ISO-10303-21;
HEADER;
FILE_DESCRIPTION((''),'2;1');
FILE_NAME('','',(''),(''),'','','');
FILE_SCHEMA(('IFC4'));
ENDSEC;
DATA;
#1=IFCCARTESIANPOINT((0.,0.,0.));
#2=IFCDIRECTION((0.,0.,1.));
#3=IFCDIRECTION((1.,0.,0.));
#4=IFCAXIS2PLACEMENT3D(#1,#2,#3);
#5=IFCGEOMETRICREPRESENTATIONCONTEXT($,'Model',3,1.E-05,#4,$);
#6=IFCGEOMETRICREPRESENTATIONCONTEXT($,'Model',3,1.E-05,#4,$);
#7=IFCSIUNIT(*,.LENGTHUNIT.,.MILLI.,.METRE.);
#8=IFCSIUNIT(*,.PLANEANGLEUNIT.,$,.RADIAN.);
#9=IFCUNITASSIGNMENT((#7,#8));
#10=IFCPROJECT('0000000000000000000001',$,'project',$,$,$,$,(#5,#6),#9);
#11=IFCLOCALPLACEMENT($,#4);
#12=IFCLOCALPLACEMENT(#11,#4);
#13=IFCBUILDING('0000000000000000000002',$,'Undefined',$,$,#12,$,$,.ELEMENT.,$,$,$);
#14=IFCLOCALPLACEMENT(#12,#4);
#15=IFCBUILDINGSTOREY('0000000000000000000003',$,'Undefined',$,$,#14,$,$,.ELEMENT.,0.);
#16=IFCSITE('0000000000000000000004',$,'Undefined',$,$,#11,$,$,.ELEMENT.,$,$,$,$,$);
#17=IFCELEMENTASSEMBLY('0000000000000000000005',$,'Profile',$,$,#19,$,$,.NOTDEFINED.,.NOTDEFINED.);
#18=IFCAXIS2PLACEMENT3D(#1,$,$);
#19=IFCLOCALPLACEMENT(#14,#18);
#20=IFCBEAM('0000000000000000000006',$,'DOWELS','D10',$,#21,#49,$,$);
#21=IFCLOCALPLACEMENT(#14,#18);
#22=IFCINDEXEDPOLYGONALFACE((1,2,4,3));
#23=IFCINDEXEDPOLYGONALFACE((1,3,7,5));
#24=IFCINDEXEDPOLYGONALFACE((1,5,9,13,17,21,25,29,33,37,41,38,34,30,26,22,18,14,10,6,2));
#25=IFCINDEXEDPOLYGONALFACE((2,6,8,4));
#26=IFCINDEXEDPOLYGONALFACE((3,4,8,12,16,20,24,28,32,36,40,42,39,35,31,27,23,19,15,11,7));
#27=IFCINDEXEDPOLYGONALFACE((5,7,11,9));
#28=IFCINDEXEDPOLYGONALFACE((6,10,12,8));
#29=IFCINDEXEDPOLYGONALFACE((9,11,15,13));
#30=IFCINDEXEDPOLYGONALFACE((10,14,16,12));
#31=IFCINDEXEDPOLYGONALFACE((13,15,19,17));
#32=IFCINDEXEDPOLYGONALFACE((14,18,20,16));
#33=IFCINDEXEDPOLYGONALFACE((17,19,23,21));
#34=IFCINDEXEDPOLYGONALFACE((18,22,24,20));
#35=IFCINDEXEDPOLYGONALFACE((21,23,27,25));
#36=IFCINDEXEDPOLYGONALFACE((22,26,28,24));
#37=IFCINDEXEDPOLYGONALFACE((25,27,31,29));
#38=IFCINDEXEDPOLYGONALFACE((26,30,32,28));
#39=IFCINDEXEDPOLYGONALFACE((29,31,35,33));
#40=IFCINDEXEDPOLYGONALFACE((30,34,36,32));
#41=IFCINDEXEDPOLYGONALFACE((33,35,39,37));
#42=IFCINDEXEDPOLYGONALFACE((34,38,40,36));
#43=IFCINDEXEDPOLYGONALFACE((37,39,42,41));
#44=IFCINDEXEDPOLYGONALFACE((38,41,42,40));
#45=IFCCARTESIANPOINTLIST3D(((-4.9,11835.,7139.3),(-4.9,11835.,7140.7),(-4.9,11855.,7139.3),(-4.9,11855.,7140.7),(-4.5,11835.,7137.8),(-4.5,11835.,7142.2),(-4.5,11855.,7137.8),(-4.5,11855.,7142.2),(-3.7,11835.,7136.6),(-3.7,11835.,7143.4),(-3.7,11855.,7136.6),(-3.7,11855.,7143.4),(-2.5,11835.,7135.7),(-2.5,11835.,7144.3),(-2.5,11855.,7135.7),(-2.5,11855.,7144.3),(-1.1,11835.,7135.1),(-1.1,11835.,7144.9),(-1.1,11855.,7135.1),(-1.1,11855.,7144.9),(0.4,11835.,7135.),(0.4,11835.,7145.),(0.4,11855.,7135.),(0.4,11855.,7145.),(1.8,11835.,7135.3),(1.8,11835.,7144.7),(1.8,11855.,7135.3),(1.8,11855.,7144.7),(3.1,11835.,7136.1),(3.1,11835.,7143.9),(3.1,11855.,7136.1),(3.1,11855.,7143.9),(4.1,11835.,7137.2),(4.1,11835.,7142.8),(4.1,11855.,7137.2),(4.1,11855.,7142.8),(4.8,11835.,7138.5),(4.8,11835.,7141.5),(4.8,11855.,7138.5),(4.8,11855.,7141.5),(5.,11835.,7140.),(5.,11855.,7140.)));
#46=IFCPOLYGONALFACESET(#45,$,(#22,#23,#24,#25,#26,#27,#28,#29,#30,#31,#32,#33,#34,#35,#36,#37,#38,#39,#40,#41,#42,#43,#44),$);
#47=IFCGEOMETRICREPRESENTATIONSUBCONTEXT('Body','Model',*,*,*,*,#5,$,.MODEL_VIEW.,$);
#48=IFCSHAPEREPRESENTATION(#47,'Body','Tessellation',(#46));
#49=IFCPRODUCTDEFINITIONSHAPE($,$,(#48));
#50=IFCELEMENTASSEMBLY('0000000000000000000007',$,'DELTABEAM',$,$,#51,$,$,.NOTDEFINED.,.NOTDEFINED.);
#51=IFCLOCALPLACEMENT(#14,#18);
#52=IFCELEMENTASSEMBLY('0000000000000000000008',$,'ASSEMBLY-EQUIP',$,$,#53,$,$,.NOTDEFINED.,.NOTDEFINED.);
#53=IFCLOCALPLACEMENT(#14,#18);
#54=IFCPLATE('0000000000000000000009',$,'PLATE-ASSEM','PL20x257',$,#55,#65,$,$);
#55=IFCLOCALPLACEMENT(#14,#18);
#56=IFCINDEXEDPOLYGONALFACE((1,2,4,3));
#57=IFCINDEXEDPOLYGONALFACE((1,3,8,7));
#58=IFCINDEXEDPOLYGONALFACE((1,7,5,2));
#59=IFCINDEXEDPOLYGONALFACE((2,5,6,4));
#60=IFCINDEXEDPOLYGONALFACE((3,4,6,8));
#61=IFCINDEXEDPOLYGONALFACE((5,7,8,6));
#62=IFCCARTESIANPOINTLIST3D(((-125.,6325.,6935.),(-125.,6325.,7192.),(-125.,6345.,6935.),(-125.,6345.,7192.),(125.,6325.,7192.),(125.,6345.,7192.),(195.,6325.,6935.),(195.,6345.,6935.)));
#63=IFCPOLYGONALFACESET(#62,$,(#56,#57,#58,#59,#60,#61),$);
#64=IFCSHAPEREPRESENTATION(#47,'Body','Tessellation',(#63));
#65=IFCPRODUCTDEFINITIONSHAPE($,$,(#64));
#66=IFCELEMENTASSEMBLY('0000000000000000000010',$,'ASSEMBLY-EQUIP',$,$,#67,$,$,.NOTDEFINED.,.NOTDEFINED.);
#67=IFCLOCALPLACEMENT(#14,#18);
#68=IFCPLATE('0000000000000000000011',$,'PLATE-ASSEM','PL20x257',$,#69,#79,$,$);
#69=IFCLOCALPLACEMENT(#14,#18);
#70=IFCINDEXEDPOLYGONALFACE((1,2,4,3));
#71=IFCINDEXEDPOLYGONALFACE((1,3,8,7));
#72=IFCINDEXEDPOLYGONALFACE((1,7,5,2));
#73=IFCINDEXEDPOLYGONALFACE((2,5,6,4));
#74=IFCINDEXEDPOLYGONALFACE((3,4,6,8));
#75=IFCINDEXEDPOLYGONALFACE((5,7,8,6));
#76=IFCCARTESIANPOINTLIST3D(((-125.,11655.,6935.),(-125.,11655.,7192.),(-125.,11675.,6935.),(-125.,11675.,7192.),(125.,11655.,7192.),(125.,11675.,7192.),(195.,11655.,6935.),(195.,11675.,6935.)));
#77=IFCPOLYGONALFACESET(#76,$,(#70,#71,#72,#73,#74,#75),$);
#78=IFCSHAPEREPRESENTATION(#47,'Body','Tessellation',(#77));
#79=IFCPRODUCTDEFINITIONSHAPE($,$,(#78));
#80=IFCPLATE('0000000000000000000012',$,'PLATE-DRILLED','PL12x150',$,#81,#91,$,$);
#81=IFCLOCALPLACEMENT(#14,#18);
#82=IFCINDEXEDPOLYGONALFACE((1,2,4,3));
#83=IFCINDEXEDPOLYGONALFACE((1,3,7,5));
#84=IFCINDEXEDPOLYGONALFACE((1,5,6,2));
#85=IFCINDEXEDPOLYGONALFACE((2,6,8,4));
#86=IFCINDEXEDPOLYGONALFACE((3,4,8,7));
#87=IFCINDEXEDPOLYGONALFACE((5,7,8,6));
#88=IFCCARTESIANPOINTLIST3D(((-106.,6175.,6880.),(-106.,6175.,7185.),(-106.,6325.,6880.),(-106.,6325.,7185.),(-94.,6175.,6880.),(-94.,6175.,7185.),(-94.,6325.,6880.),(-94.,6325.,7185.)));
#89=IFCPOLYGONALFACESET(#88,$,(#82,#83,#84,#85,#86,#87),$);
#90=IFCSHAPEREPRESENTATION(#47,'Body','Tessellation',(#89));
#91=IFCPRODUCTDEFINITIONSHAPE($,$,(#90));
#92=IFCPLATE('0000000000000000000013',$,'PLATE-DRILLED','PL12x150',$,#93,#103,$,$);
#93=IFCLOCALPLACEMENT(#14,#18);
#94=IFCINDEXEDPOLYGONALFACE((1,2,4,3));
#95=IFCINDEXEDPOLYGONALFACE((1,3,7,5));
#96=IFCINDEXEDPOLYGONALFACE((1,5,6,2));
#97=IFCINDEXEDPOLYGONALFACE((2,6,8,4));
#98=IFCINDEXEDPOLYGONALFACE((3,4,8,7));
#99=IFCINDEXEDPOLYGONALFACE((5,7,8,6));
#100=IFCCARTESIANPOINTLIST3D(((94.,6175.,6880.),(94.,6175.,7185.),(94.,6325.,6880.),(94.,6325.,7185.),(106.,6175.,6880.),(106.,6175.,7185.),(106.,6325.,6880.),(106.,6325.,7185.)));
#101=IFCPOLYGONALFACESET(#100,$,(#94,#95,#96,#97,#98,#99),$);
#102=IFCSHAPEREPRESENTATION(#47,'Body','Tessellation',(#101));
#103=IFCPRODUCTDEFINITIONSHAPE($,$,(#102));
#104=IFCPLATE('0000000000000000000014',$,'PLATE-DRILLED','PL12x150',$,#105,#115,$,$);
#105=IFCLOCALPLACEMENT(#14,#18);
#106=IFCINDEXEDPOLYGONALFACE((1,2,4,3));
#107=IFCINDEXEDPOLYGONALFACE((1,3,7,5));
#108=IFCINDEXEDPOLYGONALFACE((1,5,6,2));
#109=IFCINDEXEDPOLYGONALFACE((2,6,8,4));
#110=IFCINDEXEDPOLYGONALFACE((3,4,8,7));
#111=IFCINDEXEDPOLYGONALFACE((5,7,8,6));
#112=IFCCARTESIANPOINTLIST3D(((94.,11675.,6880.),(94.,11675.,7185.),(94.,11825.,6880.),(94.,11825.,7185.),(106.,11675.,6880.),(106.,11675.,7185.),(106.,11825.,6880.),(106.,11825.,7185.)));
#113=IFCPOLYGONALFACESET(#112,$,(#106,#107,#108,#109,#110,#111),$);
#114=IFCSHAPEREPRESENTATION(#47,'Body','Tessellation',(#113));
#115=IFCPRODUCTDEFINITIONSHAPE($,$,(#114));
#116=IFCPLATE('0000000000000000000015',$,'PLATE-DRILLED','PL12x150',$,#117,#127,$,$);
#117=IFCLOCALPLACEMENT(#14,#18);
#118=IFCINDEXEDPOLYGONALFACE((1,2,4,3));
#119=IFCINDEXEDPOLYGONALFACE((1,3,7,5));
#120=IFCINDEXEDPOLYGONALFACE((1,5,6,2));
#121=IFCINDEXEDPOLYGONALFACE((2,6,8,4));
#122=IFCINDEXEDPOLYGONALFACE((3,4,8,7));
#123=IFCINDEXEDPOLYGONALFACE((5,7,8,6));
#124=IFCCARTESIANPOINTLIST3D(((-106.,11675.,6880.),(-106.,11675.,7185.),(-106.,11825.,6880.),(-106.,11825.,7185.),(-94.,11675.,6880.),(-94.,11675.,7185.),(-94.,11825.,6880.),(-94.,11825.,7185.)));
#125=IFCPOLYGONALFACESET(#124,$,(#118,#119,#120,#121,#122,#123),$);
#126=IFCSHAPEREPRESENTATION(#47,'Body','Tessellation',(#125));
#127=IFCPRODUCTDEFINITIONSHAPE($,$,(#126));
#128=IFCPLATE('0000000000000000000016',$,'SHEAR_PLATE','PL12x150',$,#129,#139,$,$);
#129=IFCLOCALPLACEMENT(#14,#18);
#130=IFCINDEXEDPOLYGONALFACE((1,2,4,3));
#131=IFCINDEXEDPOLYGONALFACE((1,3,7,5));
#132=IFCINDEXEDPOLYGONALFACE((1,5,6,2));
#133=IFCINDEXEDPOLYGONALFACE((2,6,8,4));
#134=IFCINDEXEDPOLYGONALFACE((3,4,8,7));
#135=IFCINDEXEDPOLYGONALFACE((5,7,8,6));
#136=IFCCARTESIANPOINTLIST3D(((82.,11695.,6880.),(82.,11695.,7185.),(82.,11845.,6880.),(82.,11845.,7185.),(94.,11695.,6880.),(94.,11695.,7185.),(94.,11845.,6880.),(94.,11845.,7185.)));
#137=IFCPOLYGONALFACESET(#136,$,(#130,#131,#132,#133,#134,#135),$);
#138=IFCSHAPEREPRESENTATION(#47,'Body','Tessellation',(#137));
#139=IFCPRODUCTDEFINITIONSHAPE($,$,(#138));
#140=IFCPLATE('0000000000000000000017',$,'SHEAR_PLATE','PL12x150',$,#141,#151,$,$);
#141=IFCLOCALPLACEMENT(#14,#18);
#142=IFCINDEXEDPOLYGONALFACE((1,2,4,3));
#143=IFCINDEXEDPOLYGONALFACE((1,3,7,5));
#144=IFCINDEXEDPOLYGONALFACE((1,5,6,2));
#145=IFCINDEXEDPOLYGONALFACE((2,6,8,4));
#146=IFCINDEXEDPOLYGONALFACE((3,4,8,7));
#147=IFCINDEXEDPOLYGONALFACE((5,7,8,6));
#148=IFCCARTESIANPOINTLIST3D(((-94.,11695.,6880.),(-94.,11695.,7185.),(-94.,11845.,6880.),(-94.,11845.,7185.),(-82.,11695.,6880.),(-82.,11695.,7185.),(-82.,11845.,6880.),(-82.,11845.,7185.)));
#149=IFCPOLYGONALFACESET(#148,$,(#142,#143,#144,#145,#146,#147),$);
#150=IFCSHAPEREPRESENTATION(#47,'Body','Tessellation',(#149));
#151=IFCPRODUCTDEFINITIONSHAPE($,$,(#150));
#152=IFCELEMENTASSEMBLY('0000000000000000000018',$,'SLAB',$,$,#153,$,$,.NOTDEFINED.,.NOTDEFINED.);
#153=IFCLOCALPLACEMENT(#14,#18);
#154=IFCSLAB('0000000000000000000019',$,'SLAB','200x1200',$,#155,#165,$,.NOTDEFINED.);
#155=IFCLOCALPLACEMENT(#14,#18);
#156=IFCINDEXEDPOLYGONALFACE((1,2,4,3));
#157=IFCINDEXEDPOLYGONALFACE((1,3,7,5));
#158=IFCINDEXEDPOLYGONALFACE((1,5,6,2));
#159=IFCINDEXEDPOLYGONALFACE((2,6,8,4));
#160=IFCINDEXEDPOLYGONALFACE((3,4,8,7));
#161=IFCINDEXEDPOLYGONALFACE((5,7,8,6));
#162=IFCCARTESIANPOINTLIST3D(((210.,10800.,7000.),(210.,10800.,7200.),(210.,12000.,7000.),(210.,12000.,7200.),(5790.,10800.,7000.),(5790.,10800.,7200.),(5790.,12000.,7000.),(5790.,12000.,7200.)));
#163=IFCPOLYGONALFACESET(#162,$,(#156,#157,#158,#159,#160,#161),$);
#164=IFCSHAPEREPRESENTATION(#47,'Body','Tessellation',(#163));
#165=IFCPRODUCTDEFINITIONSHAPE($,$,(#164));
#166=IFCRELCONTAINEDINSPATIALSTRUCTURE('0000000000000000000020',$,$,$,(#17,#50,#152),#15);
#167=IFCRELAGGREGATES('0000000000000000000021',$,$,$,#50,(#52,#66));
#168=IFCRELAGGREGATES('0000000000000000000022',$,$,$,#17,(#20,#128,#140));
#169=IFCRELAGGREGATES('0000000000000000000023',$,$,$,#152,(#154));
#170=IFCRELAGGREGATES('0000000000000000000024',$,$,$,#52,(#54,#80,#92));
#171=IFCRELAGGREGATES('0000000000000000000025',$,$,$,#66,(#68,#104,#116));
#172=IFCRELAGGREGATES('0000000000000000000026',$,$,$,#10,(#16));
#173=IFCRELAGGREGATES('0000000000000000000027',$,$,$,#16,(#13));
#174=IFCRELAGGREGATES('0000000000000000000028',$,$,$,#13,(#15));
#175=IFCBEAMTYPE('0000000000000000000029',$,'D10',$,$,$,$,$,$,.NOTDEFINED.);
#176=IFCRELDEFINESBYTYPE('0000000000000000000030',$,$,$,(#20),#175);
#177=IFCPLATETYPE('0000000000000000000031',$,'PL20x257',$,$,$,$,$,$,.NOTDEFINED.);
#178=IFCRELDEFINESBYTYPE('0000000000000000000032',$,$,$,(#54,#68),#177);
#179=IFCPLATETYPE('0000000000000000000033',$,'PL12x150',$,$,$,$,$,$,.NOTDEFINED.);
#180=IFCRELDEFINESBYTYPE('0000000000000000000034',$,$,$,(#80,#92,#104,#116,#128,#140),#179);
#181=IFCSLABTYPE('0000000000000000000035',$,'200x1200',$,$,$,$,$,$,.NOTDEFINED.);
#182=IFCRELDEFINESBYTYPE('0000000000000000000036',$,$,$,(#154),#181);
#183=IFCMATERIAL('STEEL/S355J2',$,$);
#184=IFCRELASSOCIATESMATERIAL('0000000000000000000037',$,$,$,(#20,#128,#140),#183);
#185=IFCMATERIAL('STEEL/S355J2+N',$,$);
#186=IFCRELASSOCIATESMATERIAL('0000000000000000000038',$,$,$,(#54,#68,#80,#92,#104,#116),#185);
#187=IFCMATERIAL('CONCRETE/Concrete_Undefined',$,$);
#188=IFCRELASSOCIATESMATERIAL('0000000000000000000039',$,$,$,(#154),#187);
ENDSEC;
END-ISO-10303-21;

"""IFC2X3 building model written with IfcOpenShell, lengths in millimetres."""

from ifc_helpers import new_model, si_unit, frame, origin_with_axes, origin_2d_with_axis, place, context, subcontext, project, spatial, polyline, circle, outline, extrude, material, type_object, element, aggregate, save


model = new_model("IFC2X3")

# Units and contexts
model_context_1 = context("Model", 3, precision=1e-05, world=origin_with_axes())
model_context_2 = context("Model", 3, precision=1e-05, world=origin_with_axes())
body_context = subcontext(model_context_1, "Body", "Model", "MODEL_VIEW")
ifc_project = project(units=[si_unit("LENGTHUNIT", "METRE", prefix="MILLI"), si_unit("PLANEANGLEUNIT", "RADIAN")], contexts=[model_context_1, model_context_2])

# Site, building, storey
site_placement = place(None, origin_with_axes())
site = spatial("IfcSite", under=ifc_project, at=site_placement, Name="Undefined", CompositionType="ELEMENT")
building_placement = place(site_placement, origin_with_axes())
building = spatial("IfcBuilding", under=site, at=building_placement, Name="Undefined", CompositionType="ELEMENT")
storey_placement = place(building_placement, origin_with_axes())
storey = spatial("IfcBuildingStorey", under=building, at=storey_placement, Name="Undefined", CompositionType="ELEMENT", Elevation=0.0)

# Element assembly, beam
assembly_1_placement = place(storey_placement, origin_with_axes())
assembly_1 = element("IfcElementAssembly", 1, at=assembly_1_placement, inside=storey, Name="Profile", AssemblyPlace="NOTDEFINED", PredefinedType="NOTDEFINED")
ifc_material_1 = material(Name="STEEL/S355J2")
beam_type_1 = type_object("IfcBeamType", Name="D10", PredefinedType="NOTDEFINED")
beam_1_placement = place(assembly_1_placement, frame((0.0, 11835.0, 7140.0), z_axis=(0.0, 0.0, 1.0), x_axis=(0.0, 1.0, 0.0)))
beam_1 = element("IfcBeam", 2, at=beam_1_placement, type_object=beam_type_1, material=ifc_material_1, Name="DOWELS", Description="D10", context=body_context, shape_type="SweptSolid", body=[
    extrude(circle(Radius=5.0, at=origin_2d_with_axis()), frame((20.0, 0.0, 0.0), z_axis=(-1.0, 0.0, 0.0), x_axis=(0.0, -1.0, 0.0)), (0.0, 0.0, 1.0), 20.0),
])

# Element assemblies, plates
assembly_2_placement = place(storey_placement, origin_with_axes())
assembly_2 = element("IfcElementAssembly", 3, at=assembly_2_placement, inside=storey, Name="DELTABEAM", AssemblyPlace="NOTDEFINED", PredefinedType="NOTDEFINED")
assembly_3_placement = place(assembly_2_placement, origin_with_axes())
assembly_3 = element("IfcElementAssembly", 4, at=assembly_3_placement, Name="ASSEMBLY-EQUIP", AssemblyPlace="NOTDEFINED", PredefinedType="NOTDEFINED")
ifc_material_2 = material(Name="STEEL/S355J2+N")
plate_type_1 = type_object("IfcPlateType", Name="PL20x257", PredefinedType="NOTDEFINED")
plate_1_placement = place(assembly_3_placement, frame((195.0, 6335.0, 6935.0), z_axis=(0.0, 1.0, 0.0), x_axis=(-1.0, 0.0, 0.0)))
plate_1 = element("IfcPlate", 5, at=plate_1_placement, type_object=plate_type_1, material=ifc_material_2, Name="PLATE-ASSEM", Description="PL20x257", context=body_context, shape_type="SweptSolid", body=[
    extrude(outline(polyline([(0.0, 0.0), (320.0, 0.0), (320.0, 257.0), (70.0, 257.0), (0.0, 0.0)])), frame((0.0, 0.0, -10.0), z_axis=(0.0, 0.0, 1.0), x_axis=(1.0, 0.0, 0.0)), (0.0, 0.0, 1.0), 20.0),
])
assembly_4_placement = place(assembly_2_placement, origin_with_axes())
assembly_4 = element("IfcElementAssembly", 6, at=assembly_4_placement, Name="ASSEMBLY-EQUIP", AssemblyPlace="NOTDEFINED", PredefinedType="NOTDEFINED")
aggregate(assembly_2, [assembly_3, assembly_4])
plate_2_placement = place(assembly_4_placement, frame((-125.0, 11665.0, 6935.0), z_axis=(0.0, -1.0, 0.0), x_axis=(1.0, 0.0, 0.0)))
plate_2 = element("IfcPlate", 7, at=plate_2_placement, type_object=plate_type_1, material=ifc_material_2, Name="PLATE-ASSEM", Description="PL20x257", context=body_context, shape_type="SweptSolid", body=[
    extrude(outline(polyline([(0.0, 0.0), (320.0, 0.0), (250.0, 257.0), (0.0, 257.0), (0.0, 0.0)])), frame((0.0, 0.0, -10.0), z_axis=(0.0, 0.0, 1.0), x_axis=(1.0, 0.0, 0.0)), (0.0, 0.0, 1.0), 20.0),
])
plate_type_2 = type_object("IfcPlateType", Name="PL12x150", PredefinedType="NOTDEFINED")
plate_3_placement = place(assembly_3_placement, frame((-100.0, 6325.0, 7185.0), z_axis=(1.0, 0.0, 0.0), x_axis=(0.0, -1.0, 0.0)))
plate_3 = element("IfcPlate", 8, at=plate_3_placement, type_object=plate_type_2, material=ifc_material_2, Name="PLATE-DRILLED", Description="PL12x150", context=body_context, shape_type="SweptSolid", body=[
    extrude(outline(polyline([(0.0, 0.0), (150.0, 0.0), (150.0, 0.0), (150.0, 305.0), (150.0, 305.0), (0.0, 305.0), (0.0, 305.0), (0.0, 0.0)])), frame((0.0, 0.0, -6.0), z_axis=(0.0, 0.0, 1.0), x_axis=(1.0, 0.0, 0.0)), (0.0, 0.0, 1.0), 12.0),
])
plate_4_placement = place(assembly_3_placement, frame((100.0, 6325.0, 7185.0), z_axis=(1.0, 0.0, 0.0), x_axis=(0.0, -1.0, 0.0)))
plate_4 = element("IfcPlate", 9, at=plate_4_placement, type_object=plate_type_2, material=ifc_material_2, Name="PLATE-DRILLED", Description="PL12x150", context=body_context, shape_type="SweptSolid", body=[
    extrude(outline(polyline([(0.0, 0.0), (150.0, 0.0), (150.0, 0.0), (150.0, 305.0), (150.0, 305.0), (0.0, 305.0), (0.0, 305.0), (0.0, 0.0)])), frame((0.0, 0.0, -6.0), z_axis=(0.0, 0.0, 1.0), x_axis=(1.0, 0.0, 0.0)), (0.0, 0.0, 1.0), 12.0),
])
plate_5_placement = place(assembly_4_placement, frame((100.0, 11675.0, 7185.0), z_axis=(-1.0, 0.0, 0.0), x_axis=(0.0, 1.0, 0.0)))
plate_5 = element("IfcPlate", 10, at=plate_5_placement, type_object=plate_type_2, material=ifc_material_2, Name="PLATE-DRILLED", Description="PL12x150", context=body_context, shape_type="SweptSolid", body=[
    extrude(outline(polyline([(0.0, 0.0), (150.0, 0.0), (150.0, 0.0), (150.0, 305.0), (150.0, 305.0), (0.0, 305.0), (0.0, 305.0), (0.0, 0.0)])), frame((0.0, 0.0, -6.0), z_axis=(0.0, 0.0, 1.0), x_axis=(1.0, 0.0, 0.0)), (0.0, 0.0, 1.0), 12.0),
])
plate_6_placement = place(assembly_4_placement, frame((-100.0, 11675.0, 7185.0), z_axis=(-1.0, 0.0, 0.0), x_axis=(0.0, 1.0, 0.0)))
plate_6 = element("IfcPlate", 11, at=plate_6_placement, type_object=plate_type_2, material=ifc_material_2, Name="PLATE-DRILLED", Description="PL12x150", context=body_context, shape_type="SweptSolid", body=[
    extrude(outline(polyline([(0.0, 0.0), (150.0, 0.0), (150.0, 0.0), (150.0, 305.0), (150.0, 305.0), (0.0, 305.0), (0.0, 305.0), (0.0, 0.0)])), frame((0.0, 0.0, -6.0), z_axis=(0.0, 0.0, 1.0), x_axis=(1.0, 0.0, 0.0)), (0.0, 0.0, 1.0), 12.0),
])

# Plates
plate_7_placement = place(assembly_1_placement, frame((88.0, 11845.0, 7185.0), z_axis=(1.0, 0.0, 0.0), x_axis=(0.0, -1.0, 0.0)))
plate_7 = element("IfcPlate", 12, at=plate_7_placement, type_object=plate_type_2, material=ifc_material_1, Name="SHEAR_PLATE", Description="PL12x150", context=body_context, shape_type="SweptSolid", body=[
    extrude(outline(polyline([(0.0, 0.0), (150.0, 0.0), (150.0, 0.0), (150.0, 305.0), (150.0, 305.0), (0.0, 305.0), (0.0, 305.0), (0.0, 0.0)])), frame((0.0, 0.0, -6.0), z_axis=(0.0, 0.0, 1.0), x_axis=(1.0, 0.0, 0.0)), (0.0, 0.0, 1.0), 12.0),
])
plate_8_placement = place(assembly_1_placement, frame((-88.0, 11845.0, 7185.0), z_axis=(1.0, 0.0, 0.0), x_axis=(0.0, -1.0, 0.0)))
plate_8 = element("IfcPlate", 13, at=plate_8_placement, type_object=plate_type_2, material=ifc_material_1, Name="SHEAR_PLATE", Description="PL12x150", context=body_context, shape_type="SweptSolid", body=[
    extrude(outline(polyline([(0.0, 0.0), (150.0, 0.0), (150.0, 0.0), (150.0, 305.0), (150.0, 305.0), (0.0, 305.0), (0.0, 305.0), (0.0, 0.0)])), frame((0.0, 0.0, -6.0), z_axis=(0.0, 0.0, 1.0), x_axis=(1.0, 0.0, 0.0)), (0.0, 0.0, 1.0), 12.0),
])
aggregate(assembly_1, [beam_1, plate_7, plate_8])

# Element assembly, slab
assembly_5_placement = place(storey_placement, origin_with_axes())
assembly_5 = element("IfcElementAssembly", 14, at=assembly_5_placement, inside=storey, Name="SLAB", AssemblyPlace="NOTDEFINED", PredefinedType="NOTDEFINED")
ifc_material_3 = material(Name="CONCRETE/Concrete_Undefined")
slab_type = type_object("IfcSlabType", Name="200x1200", PredefinedType="NOTDEFINED")
slab_placement = place(assembly_5_placement, frame((5790.0, 10800.0, 7100.0), z_axis=(0.0, 0.0, 1.0), x_axis=(0.0, 1.0, 0.0)))
slab = element("IfcSlab", 15, at=slab_placement, type_object=slab_type, material=ifc_material_3, Name="SLAB", Description="200x1200", PredefinedType="NOTDEFINED", context=body_context, shape_type="SweptSolid", body=[
    extrude(outline(polyline([(0.0, 0.0), (1200.0, 0.0), (1200.0, 5580.0), (0.0, 5580.0), (0.0, 0.0)])), frame((0.0, 0.0, -100.0), z_axis=(0.0, 0.0, 1.0), x_axis=(1.0, 0.0, 0.0)), (0.0, 0.0, 1.0), 200.0),
])
aggregate(assembly_5, [slab])

aggregate(assembly_3, [plate_1, plate_3, plate_4])
aggregate(assembly_4, [plate_2, plate_5, plate_6])

save(model, "model.ifc")
